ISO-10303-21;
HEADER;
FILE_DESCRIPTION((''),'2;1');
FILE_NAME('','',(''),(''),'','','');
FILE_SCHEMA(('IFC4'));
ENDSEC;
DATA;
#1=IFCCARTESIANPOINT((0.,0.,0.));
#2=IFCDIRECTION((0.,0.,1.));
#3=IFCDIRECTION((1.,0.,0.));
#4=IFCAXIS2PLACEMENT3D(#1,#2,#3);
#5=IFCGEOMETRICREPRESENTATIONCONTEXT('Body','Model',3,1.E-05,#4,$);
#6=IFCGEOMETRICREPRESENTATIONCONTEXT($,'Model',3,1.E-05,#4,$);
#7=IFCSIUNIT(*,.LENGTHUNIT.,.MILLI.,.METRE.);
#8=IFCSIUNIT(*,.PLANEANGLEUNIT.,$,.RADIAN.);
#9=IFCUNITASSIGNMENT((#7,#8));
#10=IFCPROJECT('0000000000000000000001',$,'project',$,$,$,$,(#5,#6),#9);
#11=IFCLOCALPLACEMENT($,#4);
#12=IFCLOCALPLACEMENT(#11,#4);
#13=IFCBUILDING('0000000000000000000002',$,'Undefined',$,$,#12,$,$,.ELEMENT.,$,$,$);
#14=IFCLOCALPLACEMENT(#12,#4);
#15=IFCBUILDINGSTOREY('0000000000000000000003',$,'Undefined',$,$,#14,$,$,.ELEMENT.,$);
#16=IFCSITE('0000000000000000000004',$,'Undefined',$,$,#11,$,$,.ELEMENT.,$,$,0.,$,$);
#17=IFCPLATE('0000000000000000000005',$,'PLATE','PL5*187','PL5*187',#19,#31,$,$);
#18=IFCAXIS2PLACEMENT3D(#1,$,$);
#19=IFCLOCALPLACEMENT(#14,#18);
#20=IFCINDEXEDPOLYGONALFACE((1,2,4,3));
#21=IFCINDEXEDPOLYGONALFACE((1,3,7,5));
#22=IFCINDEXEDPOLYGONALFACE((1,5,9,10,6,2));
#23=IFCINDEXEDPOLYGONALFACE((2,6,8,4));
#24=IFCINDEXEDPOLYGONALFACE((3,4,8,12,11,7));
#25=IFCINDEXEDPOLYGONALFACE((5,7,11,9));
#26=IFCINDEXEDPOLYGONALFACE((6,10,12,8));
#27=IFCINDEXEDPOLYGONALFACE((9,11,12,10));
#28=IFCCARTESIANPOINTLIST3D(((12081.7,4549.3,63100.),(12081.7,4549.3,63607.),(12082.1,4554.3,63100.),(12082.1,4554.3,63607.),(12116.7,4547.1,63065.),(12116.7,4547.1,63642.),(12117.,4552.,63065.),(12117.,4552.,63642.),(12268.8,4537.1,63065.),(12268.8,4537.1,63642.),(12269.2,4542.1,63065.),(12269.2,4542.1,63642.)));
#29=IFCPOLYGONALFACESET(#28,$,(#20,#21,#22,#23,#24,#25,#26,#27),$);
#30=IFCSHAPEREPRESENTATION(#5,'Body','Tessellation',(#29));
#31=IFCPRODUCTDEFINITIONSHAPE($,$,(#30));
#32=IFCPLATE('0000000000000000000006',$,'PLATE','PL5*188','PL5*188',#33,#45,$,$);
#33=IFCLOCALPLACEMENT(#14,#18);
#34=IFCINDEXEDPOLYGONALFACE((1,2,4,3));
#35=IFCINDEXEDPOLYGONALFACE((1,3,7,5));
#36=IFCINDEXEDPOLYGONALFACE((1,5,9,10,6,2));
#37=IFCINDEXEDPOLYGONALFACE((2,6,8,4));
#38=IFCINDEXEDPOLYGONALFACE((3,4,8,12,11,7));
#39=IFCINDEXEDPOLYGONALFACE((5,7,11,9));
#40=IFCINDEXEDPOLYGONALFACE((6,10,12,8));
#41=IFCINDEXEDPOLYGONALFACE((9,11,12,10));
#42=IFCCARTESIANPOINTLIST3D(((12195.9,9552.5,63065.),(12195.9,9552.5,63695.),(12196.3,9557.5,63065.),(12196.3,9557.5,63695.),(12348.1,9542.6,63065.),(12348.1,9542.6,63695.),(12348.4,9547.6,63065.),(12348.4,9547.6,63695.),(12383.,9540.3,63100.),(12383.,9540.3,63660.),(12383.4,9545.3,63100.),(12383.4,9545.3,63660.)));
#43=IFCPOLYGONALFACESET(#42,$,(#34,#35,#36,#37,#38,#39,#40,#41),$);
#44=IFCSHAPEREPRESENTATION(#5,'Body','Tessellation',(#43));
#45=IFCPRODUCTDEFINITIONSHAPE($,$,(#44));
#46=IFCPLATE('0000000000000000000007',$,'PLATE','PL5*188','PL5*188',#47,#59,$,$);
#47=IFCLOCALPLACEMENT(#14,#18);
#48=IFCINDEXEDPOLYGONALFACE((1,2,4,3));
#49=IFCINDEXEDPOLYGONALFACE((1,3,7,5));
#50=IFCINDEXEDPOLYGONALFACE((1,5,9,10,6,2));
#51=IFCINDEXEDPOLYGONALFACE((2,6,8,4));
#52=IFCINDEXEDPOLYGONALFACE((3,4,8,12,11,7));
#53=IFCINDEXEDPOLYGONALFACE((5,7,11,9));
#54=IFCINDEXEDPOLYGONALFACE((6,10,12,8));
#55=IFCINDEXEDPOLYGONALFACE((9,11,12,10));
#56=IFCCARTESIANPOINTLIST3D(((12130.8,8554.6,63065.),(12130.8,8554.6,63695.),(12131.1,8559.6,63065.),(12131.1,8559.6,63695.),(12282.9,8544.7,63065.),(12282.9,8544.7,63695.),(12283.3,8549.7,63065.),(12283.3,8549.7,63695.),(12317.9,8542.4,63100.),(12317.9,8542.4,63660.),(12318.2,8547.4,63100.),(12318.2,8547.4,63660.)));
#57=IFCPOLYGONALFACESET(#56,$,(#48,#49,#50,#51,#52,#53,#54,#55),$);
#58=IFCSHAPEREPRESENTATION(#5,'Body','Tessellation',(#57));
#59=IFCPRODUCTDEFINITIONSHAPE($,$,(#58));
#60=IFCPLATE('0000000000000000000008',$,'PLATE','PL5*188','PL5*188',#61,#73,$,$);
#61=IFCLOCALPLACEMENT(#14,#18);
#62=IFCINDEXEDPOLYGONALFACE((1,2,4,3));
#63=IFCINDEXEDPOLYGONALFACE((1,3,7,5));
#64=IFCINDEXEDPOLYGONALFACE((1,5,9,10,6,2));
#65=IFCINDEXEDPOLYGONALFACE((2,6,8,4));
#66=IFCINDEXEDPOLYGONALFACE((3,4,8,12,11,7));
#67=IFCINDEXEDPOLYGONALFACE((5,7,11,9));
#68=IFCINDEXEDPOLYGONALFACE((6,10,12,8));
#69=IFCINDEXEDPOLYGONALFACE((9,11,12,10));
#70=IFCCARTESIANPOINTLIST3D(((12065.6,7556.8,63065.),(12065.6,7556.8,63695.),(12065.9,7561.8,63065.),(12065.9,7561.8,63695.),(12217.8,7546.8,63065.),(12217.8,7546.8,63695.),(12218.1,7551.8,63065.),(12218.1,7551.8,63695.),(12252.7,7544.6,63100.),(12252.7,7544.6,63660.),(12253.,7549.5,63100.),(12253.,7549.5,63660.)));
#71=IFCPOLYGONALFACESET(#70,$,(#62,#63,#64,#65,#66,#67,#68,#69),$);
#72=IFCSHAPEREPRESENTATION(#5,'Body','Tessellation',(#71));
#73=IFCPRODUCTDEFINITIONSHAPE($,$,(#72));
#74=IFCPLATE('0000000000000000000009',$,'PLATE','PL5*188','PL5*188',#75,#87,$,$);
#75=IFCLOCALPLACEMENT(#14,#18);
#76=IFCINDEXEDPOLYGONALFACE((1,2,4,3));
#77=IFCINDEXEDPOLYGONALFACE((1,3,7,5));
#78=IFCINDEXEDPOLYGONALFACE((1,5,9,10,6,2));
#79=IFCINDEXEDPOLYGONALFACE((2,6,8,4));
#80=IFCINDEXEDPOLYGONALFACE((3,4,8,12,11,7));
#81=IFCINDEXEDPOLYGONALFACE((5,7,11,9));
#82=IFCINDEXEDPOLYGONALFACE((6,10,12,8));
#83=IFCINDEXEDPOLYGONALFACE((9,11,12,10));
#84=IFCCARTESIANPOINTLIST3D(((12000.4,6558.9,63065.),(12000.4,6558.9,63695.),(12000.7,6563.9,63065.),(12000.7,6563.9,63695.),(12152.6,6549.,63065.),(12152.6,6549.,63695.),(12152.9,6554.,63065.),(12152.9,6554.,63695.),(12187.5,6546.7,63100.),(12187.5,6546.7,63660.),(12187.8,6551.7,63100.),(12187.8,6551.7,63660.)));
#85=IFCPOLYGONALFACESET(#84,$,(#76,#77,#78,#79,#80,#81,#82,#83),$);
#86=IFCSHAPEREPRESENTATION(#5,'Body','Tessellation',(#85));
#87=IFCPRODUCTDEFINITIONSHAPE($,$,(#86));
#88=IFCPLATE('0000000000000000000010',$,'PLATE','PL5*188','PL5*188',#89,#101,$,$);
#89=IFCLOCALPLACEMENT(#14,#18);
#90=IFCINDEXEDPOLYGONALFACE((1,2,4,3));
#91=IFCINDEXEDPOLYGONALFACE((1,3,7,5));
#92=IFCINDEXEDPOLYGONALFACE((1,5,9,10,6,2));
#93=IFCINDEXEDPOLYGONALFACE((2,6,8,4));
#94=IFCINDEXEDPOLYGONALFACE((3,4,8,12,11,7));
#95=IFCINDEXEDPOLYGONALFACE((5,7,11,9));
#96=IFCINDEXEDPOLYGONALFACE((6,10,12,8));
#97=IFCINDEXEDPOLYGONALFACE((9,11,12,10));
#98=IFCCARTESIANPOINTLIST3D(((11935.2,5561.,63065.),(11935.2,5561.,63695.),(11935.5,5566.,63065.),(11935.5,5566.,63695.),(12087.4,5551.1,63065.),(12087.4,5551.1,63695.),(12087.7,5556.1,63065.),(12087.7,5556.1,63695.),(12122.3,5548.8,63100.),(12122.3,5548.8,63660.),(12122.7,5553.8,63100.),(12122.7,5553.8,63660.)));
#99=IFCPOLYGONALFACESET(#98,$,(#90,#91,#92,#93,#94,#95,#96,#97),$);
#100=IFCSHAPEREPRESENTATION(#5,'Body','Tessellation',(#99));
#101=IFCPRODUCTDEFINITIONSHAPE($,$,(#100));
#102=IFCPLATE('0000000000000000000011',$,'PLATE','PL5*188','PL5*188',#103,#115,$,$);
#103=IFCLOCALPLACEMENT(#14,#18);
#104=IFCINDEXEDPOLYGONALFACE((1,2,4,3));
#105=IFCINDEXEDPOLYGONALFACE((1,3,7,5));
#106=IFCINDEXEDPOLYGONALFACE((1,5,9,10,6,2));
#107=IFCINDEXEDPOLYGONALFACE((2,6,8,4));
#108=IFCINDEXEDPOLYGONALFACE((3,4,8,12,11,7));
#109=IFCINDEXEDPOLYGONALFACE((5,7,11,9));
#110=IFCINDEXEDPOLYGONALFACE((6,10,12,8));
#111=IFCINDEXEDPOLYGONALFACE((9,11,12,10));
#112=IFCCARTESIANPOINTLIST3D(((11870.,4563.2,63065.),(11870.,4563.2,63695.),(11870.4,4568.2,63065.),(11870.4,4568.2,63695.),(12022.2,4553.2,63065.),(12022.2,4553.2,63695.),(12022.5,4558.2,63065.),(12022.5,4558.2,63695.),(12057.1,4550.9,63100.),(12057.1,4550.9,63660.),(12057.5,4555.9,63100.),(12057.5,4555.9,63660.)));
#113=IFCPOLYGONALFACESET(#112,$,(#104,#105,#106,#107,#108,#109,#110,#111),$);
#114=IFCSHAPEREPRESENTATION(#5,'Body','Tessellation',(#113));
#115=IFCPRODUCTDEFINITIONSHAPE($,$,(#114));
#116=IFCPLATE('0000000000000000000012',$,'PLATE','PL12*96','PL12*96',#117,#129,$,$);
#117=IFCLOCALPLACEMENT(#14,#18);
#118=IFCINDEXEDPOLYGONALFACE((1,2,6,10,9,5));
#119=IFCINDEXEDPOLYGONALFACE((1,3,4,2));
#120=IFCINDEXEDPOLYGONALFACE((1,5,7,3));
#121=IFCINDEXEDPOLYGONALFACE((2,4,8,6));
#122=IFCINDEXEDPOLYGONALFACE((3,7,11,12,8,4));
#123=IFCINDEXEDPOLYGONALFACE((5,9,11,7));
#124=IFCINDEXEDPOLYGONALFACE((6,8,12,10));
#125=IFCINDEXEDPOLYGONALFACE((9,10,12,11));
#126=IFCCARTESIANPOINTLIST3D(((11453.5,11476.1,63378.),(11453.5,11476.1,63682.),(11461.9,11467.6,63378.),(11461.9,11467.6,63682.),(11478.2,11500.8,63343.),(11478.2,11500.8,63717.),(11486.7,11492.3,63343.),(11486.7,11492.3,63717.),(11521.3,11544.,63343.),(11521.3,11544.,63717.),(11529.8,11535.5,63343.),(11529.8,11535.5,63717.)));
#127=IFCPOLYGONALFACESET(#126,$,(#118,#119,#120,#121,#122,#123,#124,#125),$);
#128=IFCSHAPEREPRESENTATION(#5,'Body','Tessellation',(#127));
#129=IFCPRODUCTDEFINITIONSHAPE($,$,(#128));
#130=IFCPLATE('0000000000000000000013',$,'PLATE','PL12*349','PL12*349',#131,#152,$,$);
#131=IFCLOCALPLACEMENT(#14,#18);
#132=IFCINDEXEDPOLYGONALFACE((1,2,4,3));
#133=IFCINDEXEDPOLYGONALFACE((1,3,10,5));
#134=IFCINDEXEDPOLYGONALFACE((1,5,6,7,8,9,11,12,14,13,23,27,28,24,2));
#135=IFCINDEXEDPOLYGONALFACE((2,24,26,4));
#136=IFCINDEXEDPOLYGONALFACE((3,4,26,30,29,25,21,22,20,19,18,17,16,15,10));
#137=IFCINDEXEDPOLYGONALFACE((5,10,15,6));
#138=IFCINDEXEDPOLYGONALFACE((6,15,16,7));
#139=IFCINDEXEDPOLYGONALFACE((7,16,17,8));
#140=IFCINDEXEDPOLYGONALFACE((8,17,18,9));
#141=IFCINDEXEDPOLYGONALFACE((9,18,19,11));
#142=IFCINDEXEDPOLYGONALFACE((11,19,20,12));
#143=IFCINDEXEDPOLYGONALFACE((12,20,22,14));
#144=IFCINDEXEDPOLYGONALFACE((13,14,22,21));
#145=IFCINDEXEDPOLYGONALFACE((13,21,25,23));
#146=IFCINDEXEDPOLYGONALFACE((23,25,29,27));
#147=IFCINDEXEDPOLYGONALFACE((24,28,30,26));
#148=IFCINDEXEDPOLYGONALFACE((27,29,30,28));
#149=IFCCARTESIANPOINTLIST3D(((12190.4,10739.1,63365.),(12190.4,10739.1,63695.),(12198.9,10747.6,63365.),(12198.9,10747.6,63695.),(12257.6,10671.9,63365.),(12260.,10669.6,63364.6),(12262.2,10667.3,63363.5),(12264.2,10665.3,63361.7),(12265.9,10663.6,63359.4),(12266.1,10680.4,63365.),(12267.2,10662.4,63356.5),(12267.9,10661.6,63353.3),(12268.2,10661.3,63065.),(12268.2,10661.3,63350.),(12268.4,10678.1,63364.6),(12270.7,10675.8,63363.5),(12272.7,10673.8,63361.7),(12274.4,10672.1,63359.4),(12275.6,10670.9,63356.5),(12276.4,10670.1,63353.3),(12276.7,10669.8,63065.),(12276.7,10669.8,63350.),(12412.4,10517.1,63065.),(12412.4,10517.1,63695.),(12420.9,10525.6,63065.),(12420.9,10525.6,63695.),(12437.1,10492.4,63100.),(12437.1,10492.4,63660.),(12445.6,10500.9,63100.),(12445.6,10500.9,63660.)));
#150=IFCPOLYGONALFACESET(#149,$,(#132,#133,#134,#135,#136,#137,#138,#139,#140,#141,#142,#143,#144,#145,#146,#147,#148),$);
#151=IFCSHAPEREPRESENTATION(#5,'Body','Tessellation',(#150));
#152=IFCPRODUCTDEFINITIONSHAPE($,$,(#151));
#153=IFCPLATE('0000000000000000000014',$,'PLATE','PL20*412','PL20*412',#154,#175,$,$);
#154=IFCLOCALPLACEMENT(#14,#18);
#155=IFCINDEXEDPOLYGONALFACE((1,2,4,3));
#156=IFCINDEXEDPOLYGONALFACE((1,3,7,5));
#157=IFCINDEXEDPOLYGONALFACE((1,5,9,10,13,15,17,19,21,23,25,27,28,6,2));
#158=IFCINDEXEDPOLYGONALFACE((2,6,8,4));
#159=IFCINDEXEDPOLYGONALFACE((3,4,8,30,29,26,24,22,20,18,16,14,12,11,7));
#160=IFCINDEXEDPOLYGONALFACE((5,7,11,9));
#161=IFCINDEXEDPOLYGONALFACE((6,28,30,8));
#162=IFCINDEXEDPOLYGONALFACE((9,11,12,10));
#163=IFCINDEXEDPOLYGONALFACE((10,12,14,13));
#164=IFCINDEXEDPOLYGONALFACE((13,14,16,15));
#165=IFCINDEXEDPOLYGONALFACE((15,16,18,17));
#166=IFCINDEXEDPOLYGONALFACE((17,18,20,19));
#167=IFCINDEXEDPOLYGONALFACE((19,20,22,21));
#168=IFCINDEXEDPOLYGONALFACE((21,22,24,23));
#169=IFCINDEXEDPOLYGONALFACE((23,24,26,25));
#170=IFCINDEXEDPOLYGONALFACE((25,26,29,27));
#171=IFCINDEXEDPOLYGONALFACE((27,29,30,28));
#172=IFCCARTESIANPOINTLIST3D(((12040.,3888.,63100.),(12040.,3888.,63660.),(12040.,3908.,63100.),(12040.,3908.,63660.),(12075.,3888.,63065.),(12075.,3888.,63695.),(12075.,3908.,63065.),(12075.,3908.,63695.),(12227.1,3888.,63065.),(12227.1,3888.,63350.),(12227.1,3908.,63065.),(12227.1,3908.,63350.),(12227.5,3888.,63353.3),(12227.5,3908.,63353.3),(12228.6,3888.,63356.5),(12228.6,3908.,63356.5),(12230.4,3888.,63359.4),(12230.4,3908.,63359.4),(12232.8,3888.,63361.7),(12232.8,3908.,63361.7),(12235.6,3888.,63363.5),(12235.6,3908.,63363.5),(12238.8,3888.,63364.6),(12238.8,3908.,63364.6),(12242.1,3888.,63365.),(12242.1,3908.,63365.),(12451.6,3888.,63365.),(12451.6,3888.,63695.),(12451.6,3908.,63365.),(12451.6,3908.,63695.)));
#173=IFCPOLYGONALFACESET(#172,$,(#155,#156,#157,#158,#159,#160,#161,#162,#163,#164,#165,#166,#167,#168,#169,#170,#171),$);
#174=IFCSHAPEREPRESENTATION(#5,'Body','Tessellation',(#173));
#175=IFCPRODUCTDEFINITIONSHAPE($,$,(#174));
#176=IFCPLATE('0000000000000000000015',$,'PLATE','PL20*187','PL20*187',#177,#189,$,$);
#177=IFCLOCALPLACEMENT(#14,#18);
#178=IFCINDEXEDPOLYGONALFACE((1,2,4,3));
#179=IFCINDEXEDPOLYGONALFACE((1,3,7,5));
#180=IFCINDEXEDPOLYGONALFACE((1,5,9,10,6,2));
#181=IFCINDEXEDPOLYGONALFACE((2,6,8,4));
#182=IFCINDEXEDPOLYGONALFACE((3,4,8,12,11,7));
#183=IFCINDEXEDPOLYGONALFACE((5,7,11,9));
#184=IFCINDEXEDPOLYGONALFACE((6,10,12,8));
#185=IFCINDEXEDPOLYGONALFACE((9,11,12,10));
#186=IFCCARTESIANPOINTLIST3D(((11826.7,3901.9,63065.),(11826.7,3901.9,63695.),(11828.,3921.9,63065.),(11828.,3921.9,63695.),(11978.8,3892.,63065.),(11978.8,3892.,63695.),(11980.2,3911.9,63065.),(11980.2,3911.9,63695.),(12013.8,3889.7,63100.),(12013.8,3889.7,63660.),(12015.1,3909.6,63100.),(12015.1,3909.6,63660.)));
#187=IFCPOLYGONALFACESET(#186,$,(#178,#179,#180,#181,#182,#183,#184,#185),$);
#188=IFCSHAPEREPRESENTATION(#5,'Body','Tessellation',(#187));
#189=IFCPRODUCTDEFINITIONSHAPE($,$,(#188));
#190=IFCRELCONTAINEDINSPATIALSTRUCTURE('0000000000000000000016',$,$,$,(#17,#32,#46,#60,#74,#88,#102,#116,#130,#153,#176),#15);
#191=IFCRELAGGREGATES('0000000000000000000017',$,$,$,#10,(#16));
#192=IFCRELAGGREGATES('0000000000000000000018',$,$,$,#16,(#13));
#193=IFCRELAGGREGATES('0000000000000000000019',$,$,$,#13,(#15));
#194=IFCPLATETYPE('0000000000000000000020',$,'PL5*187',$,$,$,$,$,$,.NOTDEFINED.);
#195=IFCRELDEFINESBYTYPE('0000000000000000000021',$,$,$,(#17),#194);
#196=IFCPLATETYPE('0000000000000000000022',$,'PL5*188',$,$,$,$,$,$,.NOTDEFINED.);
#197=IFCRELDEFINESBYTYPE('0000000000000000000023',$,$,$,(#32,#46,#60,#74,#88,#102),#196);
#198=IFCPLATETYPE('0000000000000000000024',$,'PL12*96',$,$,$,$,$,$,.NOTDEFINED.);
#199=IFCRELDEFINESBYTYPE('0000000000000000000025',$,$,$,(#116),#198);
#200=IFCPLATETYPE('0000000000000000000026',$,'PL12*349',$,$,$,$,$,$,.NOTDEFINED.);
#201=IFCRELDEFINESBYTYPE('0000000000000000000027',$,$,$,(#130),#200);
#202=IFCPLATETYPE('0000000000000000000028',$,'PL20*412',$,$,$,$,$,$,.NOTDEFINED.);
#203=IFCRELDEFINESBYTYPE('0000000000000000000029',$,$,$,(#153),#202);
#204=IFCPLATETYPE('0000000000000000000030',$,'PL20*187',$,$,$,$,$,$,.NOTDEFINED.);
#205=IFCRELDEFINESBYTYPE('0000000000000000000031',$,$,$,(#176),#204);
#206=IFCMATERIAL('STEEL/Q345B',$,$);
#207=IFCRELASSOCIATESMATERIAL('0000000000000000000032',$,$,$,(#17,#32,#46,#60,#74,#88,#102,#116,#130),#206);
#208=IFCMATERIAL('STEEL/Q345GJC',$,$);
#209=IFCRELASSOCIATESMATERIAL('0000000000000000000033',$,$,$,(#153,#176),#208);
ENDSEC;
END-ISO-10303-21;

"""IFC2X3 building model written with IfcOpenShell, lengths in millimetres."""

from ifc_helpers import new_model, si_unit, frame, origin_with_axes, place, context, project, spatial, polyline, outline, extrude, material, type_object, element, save


model = new_model("IFC2X3")

# Units and contexts
model_context_1 = context("Model", 3, precision=1e-05, world=origin_with_axes(), identifier="Body")
model_context_2 = context("Model", 3, precision=1e-05, world=origin_with_axes())
ifc_project = project(units=[si_unit("LENGTHUNIT", "METRE", prefix="MILLI"), si_unit("PLANEANGLEUNIT", "RADIAN")], contexts=[model_context_1, model_context_2])

# Site, building, storey
site_placement = place(None, origin_with_axes())
site = spatial("IfcSite", under=ifc_project, at=site_placement, Name="Undefined", CompositionType="ELEMENT", RefElevation=0.0)
building_placement = place(site_placement, origin_with_axes())
building = spatial("IfcBuilding", under=site, at=building_placement, Name="Undefined", CompositionType="ELEMENT")
storey_placement = place(building_placement, origin_with_axes())
storey = spatial("IfcBuildingStorey", under=building, at=storey_placement, Name="Undefined", CompositionType="ELEMENT")

# Shared definitions
ifc_material_1 = material(Name="STEEL/Q345B")
ifc_material_2 = material(Name="STEEL/Q345GJC")

# Plates
plate_type_1 = type_object("IfcPlateType", Name="PL5*187", PredefinedType="NOTDEFINED")
plate_1_placement = place(storey_placement, frame((12269.0, 4539.6, 63642.0), z_axis=(-0.065183, -0.997873, 0.0), x_axis=(-0.997873, 0.065184, 0.0)))
element("IfcPlate", 1, at=plate_1_placement, inside=storey, type_object=plate_type_1, material=ifc_material_1, Name="PLATE", Description="PL5*187", ObjectType="PL5*187", context=model_context_1, shape_type="SweptSolid", body=[
    extrude(outline(polyline([(0.0, 0.0), (152.5, 0.0), (187.5, 35.0), (187.5, 542.0), (152.5, 577.0), (0.0, 577.0), (0.0, 0.0)])), frame((0.0, 0.0, -2.5), z_axis=(0.0, 0.0, 1.0), x_axis=(1.0, 0.0, 0.0)), (0.0, 0.0, 1.0), 5.0),
])
plate_type_2 = type_object("IfcPlateType", Name="PL5*188", PredefinedType="NOTDEFINED")
for number, where, z_axis, x_axis, name in (
    (2, (12196.1, 9555.0, 63695.0), (0.065171, 0.997874, 0.0), (0.997874, -0.065171, 0.0), "PLATE"),
    (3, (12130.9, 8557.1, 63695.0), (0.065171, 0.997874, 0.0), (0.997874, -0.065171, 0.0), "PLATE"),
    (4, (12065.7, 7559.3, 63695.0), (0.065171, 0.997874, 0.0), (0.997874, -0.065171, 0.0), "PLATE"),
    (5, (12000.6, 6561.4, 63695.0), (0.065171, 0.997874, 0.0), (0.997874, -0.065171, 0.0), "PLATE"),
    (6, (11935.4, 5563.5, 63695.0), (0.065171, 0.997874, 0.0), (0.997874, -0.065171, 0.0), "PLATE"),
    (7, (11870.2, 4565.7, 63695.0), (0.065171, 0.997874, 0.0), (0.997874, -0.065171, 0.0), "PLATE"),
):
    element("IfcPlate", number, at=place(storey_placement, frame(where, z_axis=z_axis, x_axis=x_axis)), inside=storey, type_object=plate_type_2, material=ifc_material_1, Name=name, Description="PL5*188", ObjectType="PL5*188", context=model_context_1, shape_type="SweptSolid", body=[
        extrude(outline(polyline([(0.0, 0.0), (152.5, 0.0), (187.5, 35.0), (187.5, 595.0), (152.5, 630.0), (0.0, 630.0), (0.0, 0.0)])), frame((0.0, 0.0, -2.5), z_axis=(0.0, 0.0, 1.0), x_axis=(1.0, 0.0, 0.0)), (0.0, 0.0, 1.0), 5.0),
    ])
plate_type_3 = type_object("IfcPlateType", Name="PL12*96", PredefinedType="NOTDEFINED")
plate_2_placement = place(storey_placement, frame((11457.7, 11471.8, 63343.0), z_axis=(0.707107, -0.707107, 0.0), x_axis=(0.707107, 0.707107, 0.0)))
element("IfcPlate", 8, at=plate_2_placement, inside=storey, type_object=plate_type_3, material=ifc_material_1, Name="PLATE", Description="PL12*96", ObjectType="PL12*96", context=model_context_1, shape_type="SweptSolid", body=[
    extrude(outline(polyline([(0.0, 35.0), (35.0, 0.0), (96.0, 0.0), (96.0, 374.0), (35.0, 374.0), (0.0, 339.0), (0.0, 35.0)])), frame((0.0, 0.0, -6.0), z_axis=(0.0, 0.0, 1.0), x_axis=(1.0, 0.0, 0.0)), (0.0, 0.0, 1.0), 12.0),
])
plate_type_4 = type_object("IfcPlateType", Name="PL12*349", PredefinedType="NOTDEFINED")
plate_3_placement = place(storey_placement, frame((12194.6, 10743.4, 63695.0), z_axis=(-0.707107, -0.707107, 0.0), x_axis=(0.0, 0.0, -1.0)))
element("IfcPlate", 9, at=plate_3_placement, inside=storey, type_object=plate_type_4, material=ifc_material_1, Name="PLATE", Description="PL12*349", ObjectType="PL12*349", context=model_context_1, shape_type="SweptSolid", body=[
    extrude(outline(polyline([(0.0, 0.0), (330.0, 0.0), (330.0, 95.0), (330.4, 98.4), (331.5, 101.5), (333.3, 104.4), (335.6, 106.8), (338.5, 108.5), (341.7, 109.7), (345.0, 110.0), (630.0, 110.0), (630.0, 313.9), (595.0, 348.9), (35.0, 348.9), (0.0, 313.9), (0.0, 0.0)])), frame((0.0, 0.0, -6.0), z_axis=(0.0, 0.0, 1.0), x_axis=(1.0, 0.0, 0.0)), (0.0, 0.0, 1.0), 12.0),
])
plate_type_5 = type_object("IfcPlateType", Name="PL20*412", PredefinedType="NOTDEFINED")
plate_4_placement = place(storey_placement, frame((12040.0, 3898.0, 63695.0), z_axis=(0.0, 1.0, 0.0), x_axis=(1.0, 0.0, 0.0)))
element("IfcPlate", 10, at=plate_4_placement, inside=storey, type_object=plate_type_5, material=ifc_material_2, Name="PLATE", Description="PL20*412", ObjectType="PL20*412", context=model_context_1, shape_type="SweptSolid", body=[
    extrude(outline(polyline([(0.0, 35.0), (35.0, 0.0), (411.6, 0.0), (411.6, 330.0), (202.1, 330.0), (198.8, 330.4), (195.6, 331.5), (192.8, 333.3), (190.4, 335.6), (188.6, 338.5), (187.5, 341.7), (187.1, 345.0), (187.1, 630.0), (35.0, 630.0), (0.0, 595.0), (0.0, 35.0)])), frame((0.0, 0.0, -10.0), z_axis=(0.0, 0.0, 1.0), x_axis=(1.0, 0.0, 0.0)), (0.0, 0.0, 1.0), 20.0),
])
plate_type_6 = type_object("IfcPlateType", Name="PL20*187", PredefinedType="NOTDEFINED")
plate_5_placement = place(storey_placement, frame((12014.4, 3899.7, 63065.0), z_axis=(0.065184, 0.997873, 0.0), x_axis=(-0.997873, 0.065184, 0.0)))
element("IfcPlate", 11, at=plate_5_placement, inside=storey, type_object=plate_type_6, material=ifc_material_2, Name="PLATE", Description="PL20*187", ObjectType="PL20*187", context=model_context_1, shape_type="SweptSolid", body=[
    extrude(outline(polyline([(0.0, 35.0), (35.0, 0.0), (187.5, 0.0), (187.5, 630.0), (35.0, 630.0), (0.0, 595.0), (0.0, 35.0)])), frame((0.0, 0.0, -10.0), z_axis=(0.0, 0.0, 1.0), x_axis=(1.0, 0.0, 0.0)), (0.0, 0.0, 1.0), 20.0),
])

save(model, "model.ifc")
